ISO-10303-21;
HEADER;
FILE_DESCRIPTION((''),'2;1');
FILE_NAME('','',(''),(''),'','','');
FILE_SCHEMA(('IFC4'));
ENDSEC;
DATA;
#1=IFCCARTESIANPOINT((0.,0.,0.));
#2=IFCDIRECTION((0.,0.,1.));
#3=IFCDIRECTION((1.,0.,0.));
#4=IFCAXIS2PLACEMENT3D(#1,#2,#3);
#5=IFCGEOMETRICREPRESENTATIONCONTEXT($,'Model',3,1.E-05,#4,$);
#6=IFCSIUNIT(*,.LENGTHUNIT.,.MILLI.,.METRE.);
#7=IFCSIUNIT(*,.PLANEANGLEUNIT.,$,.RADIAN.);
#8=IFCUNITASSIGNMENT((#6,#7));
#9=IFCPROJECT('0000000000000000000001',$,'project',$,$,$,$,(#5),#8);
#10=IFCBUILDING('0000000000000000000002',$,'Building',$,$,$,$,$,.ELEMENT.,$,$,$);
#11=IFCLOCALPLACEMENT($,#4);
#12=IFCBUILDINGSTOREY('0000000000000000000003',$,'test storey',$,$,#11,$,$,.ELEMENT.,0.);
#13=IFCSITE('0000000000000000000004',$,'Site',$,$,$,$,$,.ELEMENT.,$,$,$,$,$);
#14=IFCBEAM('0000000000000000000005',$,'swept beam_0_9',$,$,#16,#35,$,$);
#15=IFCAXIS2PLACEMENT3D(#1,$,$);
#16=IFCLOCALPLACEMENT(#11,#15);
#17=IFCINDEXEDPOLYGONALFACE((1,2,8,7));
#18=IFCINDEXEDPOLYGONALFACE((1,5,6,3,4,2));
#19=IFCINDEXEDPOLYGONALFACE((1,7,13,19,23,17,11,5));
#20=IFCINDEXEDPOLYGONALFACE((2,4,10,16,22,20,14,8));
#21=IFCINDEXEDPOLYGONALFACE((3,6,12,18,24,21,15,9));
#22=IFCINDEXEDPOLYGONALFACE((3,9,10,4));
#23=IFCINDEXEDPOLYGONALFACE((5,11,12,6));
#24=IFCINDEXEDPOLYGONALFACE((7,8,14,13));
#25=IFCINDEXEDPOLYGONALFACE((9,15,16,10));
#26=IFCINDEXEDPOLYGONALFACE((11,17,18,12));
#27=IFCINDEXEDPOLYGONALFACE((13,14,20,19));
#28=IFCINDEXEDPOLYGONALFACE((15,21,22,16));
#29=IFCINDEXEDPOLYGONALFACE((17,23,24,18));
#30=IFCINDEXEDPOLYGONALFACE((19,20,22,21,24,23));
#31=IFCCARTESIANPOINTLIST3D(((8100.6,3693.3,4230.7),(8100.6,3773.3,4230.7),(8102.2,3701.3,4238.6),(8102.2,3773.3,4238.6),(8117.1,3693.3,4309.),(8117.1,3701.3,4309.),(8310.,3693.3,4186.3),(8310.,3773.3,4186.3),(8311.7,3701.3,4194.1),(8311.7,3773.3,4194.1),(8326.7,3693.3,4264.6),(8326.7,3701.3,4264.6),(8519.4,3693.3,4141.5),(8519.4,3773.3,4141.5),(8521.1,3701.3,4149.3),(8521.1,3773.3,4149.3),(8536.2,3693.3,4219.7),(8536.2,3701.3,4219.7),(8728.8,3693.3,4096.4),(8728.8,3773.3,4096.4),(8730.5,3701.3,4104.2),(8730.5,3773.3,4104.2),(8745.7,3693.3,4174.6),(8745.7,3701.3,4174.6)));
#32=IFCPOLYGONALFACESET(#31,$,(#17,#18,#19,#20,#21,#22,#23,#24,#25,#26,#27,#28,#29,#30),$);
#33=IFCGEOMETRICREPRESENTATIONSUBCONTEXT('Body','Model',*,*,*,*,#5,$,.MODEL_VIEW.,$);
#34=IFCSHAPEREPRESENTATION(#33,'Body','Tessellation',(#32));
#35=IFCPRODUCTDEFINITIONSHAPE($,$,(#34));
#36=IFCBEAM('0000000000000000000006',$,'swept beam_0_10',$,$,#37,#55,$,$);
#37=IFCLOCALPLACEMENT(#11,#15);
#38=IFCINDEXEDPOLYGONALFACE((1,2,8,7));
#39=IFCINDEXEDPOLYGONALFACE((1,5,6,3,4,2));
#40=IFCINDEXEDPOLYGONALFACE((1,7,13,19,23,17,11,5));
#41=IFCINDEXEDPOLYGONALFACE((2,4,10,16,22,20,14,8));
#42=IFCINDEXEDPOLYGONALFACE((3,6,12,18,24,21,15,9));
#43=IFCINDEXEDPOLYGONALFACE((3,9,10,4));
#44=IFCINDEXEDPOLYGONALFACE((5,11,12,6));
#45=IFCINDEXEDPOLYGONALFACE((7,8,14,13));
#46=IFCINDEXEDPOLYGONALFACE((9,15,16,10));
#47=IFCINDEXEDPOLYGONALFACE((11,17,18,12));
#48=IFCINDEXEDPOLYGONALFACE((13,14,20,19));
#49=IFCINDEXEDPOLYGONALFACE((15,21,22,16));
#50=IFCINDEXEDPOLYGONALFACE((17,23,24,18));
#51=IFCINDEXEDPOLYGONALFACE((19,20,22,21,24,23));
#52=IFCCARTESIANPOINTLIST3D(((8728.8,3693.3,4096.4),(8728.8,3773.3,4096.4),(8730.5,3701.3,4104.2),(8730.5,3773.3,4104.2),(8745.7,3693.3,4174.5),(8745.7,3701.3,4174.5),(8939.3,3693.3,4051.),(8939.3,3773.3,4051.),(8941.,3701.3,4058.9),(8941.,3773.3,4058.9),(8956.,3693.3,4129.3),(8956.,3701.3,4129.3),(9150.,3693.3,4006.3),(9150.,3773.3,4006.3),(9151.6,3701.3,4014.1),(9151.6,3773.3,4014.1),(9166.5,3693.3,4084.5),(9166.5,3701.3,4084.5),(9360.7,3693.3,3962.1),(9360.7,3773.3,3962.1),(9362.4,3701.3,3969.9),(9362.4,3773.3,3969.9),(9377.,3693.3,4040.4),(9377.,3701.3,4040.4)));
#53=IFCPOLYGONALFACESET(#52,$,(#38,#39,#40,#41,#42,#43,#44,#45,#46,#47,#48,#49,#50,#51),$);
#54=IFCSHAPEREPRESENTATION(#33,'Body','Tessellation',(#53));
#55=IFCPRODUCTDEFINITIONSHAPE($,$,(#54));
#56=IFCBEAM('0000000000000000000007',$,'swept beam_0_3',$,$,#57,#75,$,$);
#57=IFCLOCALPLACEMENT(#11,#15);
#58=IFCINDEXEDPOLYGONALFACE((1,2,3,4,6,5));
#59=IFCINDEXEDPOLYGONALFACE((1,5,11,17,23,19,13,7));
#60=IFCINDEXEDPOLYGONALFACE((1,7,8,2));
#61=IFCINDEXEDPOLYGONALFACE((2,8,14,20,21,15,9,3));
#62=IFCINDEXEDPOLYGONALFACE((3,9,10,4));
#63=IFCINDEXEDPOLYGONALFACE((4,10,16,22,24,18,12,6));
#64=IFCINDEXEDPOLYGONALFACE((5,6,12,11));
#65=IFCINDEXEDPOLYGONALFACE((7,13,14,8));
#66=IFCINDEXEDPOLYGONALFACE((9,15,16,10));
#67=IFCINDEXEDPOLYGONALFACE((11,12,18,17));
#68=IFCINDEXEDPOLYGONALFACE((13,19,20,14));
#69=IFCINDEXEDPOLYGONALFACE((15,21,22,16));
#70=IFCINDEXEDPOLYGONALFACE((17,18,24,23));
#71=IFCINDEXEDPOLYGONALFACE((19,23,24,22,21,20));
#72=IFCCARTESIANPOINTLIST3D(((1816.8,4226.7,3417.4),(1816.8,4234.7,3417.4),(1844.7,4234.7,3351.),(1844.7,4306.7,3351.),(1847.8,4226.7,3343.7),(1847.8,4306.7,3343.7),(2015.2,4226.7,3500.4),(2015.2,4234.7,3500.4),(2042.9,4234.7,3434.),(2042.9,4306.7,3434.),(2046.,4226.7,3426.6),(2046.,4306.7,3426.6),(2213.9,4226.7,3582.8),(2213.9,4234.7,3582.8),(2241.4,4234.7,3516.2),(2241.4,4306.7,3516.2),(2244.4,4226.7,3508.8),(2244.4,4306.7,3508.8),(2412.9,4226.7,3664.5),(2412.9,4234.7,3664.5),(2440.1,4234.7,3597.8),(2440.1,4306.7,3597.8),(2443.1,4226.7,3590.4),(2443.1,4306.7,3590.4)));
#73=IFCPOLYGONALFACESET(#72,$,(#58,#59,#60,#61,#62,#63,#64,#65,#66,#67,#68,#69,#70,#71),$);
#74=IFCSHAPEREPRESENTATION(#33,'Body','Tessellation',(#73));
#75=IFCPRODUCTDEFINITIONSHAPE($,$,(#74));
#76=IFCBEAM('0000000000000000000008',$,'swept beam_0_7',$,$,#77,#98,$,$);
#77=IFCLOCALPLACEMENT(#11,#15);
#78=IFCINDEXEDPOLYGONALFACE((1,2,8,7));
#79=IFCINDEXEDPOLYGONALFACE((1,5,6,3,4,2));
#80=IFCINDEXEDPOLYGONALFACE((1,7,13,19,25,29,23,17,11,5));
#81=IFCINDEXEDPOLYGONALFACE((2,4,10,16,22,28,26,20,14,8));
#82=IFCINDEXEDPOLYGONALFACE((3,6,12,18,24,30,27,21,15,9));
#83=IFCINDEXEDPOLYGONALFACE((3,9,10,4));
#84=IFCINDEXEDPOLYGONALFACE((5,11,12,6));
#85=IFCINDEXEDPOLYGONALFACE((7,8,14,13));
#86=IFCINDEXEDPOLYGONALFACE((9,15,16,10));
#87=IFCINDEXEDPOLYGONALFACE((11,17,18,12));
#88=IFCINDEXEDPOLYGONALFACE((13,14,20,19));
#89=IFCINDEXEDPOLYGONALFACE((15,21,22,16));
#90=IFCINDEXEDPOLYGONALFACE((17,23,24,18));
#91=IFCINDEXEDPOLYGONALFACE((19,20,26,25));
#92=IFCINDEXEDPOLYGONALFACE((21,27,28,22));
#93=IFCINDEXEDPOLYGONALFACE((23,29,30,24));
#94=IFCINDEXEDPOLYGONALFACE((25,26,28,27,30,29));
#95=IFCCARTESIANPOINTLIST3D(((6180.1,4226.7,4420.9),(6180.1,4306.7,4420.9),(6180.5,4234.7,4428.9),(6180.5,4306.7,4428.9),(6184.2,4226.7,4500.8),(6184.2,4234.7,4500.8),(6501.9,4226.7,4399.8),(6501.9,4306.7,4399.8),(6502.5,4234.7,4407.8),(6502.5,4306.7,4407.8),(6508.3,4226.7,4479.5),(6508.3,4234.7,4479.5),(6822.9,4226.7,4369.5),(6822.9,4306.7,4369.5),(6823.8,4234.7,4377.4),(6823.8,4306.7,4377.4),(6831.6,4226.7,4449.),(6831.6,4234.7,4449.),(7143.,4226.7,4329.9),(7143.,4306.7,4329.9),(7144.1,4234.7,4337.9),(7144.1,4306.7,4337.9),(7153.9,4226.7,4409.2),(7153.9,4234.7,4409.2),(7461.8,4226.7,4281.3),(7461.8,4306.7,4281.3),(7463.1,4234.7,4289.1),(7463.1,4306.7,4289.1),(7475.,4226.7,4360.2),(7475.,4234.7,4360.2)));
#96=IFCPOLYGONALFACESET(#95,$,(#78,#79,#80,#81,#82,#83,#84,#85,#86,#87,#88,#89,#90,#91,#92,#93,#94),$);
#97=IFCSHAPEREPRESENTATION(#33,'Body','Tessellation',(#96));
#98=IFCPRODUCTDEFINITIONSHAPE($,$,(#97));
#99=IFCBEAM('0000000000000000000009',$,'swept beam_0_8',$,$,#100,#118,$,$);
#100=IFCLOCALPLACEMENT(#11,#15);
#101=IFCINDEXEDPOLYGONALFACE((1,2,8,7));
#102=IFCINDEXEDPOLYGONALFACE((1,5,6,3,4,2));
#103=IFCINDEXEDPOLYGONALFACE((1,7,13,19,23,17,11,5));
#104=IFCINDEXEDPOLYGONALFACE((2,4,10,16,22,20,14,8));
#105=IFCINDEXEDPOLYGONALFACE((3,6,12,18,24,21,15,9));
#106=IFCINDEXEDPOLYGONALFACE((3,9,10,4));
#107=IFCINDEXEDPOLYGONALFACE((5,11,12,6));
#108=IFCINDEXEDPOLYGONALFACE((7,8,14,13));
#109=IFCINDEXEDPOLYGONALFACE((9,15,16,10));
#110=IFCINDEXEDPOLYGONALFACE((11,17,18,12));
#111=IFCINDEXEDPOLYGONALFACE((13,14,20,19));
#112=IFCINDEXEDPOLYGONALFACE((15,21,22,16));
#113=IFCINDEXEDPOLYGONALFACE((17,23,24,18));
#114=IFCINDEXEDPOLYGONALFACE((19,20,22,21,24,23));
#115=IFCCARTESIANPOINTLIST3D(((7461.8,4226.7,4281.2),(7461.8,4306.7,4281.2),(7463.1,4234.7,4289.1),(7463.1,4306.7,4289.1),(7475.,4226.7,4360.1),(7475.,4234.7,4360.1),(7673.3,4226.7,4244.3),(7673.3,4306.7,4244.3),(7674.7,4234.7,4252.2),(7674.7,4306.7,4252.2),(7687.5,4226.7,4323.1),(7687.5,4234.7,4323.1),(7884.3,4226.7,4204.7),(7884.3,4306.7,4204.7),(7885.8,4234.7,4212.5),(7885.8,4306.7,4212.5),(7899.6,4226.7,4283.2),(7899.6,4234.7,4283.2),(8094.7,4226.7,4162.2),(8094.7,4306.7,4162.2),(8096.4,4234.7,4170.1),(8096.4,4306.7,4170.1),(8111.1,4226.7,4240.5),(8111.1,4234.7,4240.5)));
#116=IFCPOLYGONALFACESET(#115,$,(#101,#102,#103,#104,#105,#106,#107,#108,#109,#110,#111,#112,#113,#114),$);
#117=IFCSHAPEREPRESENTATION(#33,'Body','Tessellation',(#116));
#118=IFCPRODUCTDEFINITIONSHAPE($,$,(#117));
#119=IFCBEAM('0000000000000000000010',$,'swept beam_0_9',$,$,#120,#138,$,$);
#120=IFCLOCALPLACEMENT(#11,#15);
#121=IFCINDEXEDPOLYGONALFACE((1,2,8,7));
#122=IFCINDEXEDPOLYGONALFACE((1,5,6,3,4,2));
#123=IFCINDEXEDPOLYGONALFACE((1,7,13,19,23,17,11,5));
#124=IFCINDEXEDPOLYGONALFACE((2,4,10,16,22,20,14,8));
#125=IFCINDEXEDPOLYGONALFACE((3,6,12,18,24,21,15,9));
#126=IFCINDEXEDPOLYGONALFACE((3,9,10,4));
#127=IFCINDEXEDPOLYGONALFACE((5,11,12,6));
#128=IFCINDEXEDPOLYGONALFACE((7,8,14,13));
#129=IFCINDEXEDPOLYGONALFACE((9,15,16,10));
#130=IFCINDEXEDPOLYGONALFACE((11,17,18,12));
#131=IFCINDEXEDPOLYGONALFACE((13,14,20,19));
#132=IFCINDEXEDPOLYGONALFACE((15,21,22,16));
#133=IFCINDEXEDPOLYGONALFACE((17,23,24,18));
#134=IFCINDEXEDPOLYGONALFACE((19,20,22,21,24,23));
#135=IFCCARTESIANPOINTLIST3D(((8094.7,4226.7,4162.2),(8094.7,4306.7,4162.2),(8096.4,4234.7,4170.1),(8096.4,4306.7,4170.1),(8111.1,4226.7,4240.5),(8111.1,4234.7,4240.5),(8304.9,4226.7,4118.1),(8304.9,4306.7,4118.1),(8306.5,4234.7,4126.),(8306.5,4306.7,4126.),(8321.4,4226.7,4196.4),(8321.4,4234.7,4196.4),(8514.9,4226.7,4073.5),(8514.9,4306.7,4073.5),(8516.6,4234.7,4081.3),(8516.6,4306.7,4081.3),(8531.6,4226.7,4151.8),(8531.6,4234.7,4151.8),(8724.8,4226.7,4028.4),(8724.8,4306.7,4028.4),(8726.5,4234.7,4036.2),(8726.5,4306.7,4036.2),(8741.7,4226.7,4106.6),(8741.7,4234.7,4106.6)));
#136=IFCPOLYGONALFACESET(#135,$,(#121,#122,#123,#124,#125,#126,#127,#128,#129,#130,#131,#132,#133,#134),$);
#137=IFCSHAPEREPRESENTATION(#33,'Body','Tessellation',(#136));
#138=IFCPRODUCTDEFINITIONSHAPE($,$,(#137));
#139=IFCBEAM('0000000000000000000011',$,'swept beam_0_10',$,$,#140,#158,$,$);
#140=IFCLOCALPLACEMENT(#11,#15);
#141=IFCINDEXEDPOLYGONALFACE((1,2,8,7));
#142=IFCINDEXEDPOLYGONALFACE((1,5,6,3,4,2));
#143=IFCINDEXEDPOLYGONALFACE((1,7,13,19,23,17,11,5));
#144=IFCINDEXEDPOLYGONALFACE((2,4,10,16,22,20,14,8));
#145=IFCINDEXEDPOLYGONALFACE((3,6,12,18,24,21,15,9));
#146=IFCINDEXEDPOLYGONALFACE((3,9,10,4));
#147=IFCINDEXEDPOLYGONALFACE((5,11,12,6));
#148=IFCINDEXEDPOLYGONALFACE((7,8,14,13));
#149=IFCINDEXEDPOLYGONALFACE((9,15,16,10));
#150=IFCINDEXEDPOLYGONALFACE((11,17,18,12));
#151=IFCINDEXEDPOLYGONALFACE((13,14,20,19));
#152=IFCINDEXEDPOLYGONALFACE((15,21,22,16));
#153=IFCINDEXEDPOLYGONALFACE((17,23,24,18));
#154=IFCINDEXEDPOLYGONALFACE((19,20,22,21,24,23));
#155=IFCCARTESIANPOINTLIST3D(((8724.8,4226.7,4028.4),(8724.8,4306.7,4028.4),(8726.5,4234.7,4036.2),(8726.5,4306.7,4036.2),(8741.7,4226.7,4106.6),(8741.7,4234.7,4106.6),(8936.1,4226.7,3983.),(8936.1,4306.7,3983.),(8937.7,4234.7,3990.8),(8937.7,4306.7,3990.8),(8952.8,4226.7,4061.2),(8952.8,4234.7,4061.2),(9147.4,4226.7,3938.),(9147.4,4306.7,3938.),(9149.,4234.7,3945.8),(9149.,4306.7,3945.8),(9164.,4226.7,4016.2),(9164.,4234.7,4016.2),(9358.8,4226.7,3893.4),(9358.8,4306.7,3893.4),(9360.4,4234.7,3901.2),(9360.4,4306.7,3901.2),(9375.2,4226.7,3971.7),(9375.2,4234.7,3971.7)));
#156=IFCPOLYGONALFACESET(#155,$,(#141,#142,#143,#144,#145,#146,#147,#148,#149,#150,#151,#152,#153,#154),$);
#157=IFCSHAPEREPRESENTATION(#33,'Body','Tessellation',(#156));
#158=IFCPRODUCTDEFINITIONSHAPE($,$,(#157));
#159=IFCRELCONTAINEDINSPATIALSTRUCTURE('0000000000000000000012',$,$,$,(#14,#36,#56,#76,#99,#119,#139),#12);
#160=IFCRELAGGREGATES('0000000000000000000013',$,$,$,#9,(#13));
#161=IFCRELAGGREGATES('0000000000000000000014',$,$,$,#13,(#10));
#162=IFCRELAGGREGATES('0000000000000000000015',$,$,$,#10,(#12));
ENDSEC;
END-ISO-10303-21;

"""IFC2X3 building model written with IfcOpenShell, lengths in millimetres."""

from ifc_helpers import new_model, entity, si_unit, origin_with_axes, place, context, subcontext, project, spatial, element, save


model = new_model("IFC2X3")

# Units and contexts
model_context = context("Model", 3, precision=1e-05, world=origin_with_axes())
body_context = subcontext(model_context, "Body", "Model", "MODEL_VIEW")
ifc_project = project(units=[si_unit("LENGTHUNIT", "METRE", prefix="MILLI"), si_unit("PLANEANGLEUNIT", "RADIAN")], contexts=[model_context])

# Site, building, storey
site = spatial("IfcSite", under=ifc_project, Name="Site", CompositionType="ELEMENT")
building = spatial("IfcBuilding", under=site, Name="Building", CompositionType="ELEMENT")
storey_placement = place(None, origin_with_axes())
storey = spatial("IfcBuildingStorey", under=building, at=storey_placement, Name="test storey", CompositionType="ELEMENT", Elevation=0.0)

# Beams
beam_1_placement = place(storey_placement, origin_with_axes())
element("IfcBeam", 1, at=beam_1_placement, inside=storey, Name="swept beam_0_9", context=body_context, shape_type="SweptSolid", body=[
    entity("IfcRevolvedAreaSolid", entity("IfcArbitraryClosedProfileDef", "AREA", None, entity("IfcPolyline", [entity("IfcCartesianPoint", [80.0, -40.0]), entity("IfcCartesianPoint", [80.0, -32.0]), entity("IfcCartesianPoint", [8.0, -32.0]), entity("IfcCartesianPoint", [8.0, 40.0]), entity("IfcCartesianPoint", [0.0, 40.0]), entity("IfcCartesianPoint", [0.0, -40.0]), entity("IfcCartesianPoint", [80.0, -40.0])])), entity("IfcAxis2Placement3D", entity("IfcCartesianPoint", [8100.6, 3733.3, 4230.7]), entity("IfcDirection", [-0.9784, 0.0, 0.2066]), entity("IfcDirection", [0.2066, 0.0, 0.9784])), entity("IfcAxis1Placement", entity("IfcCartesianPoint", [-121948.0, 0.0, 0.0]), entity("IfcDirection", [0.0, 1.0, 0.0])), 0.005268),
])
beam_2_placement = place(storey_placement, origin_with_axes())
element("IfcBeam", 2, at=beam_2_placement, inside=storey, Name="swept beam_0_10", context=body_context, shape_type="SweptSolid", body=[
    entity("IfcRevolvedAreaSolid", entity("IfcArbitraryClosedProfileDef", "AREA", None, entity("IfcPolyline", [entity("IfcCartesianPoint", [-80.0, 40.0]), entity("IfcCartesianPoint", [-80.0, 32.0]), entity("IfcCartesianPoint", [-8.0, 32.0]), entity("IfcCartesianPoint", [-8.0, -40.0]), entity("IfcCartesianPoint", [0.0, -40.0]), entity("IfcCartesianPoint", [0.0, 40.0]), entity("IfcCartesianPoint", [-80.0, 40.0])])), entity("IfcAxis2Placement3D", entity("IfcCartesianPoint", [8728.8, 3733.3, 4096.4]), entity("IfcDirection", [-0.9773, 0.0, 0.2118]), entity("IfcDirection", [-0.2118, 0.0, -0.9773])), entity("IfcAxis1Placement", entity("IfcCartesianPoint", [-80423.0, 0.0, 0.0]), entity("IfcDirection", [0.0, 1.0, 0.0])), 0.008033),
])
beam_3_placement = place(storey_placement, origin_with_axes())
element("IfcBeam", 3, at=beam_3_placement, inside=storey, Name="swept beam_0_3", context=body_context, shape_type="SweptSolid", body=[
    entity("IfcRevolvedAreaSolid", entity("IfcArbitraryClosedProfileDef", "AREA", None, entity("IfcPolyline", [entity("IfcCartesianPoint", [80.0, -40.0]), entity("IfcCartesianPoint", [80.0, -32.0]), entity("IfcCartesianPoint", [8.0, -32.0]), entity("IfcCartesianPoint", [8.0, 40.0]), entity("IfcCartesianPoint", [0.0, 40.0]), entity("IfcCartesianPoint", [0.0, -40.0]), entity("IfcCartesianPoint", [80.0, -40.0])])), entity("IfcAxis2Placement3D", entity("IfcCartesianPoint", [1847.8, 4266.7, 3343.7]), entity("IfcDirection", [-0.9219, 0.0, -0.3874]), entity("IfcDirection", [-0.3874, 0.0, 0.9219])), entity("IfcAxis1Placement", entity("IfcCartesianPoint", [-65920.5, 0.0, 0.0]), entity("IfcDirection", [0.0, 1.0, 0.0])), 0.009777),
])
beam_4_placement = place(storey_placement, origin_with_axes())
element("IfcBeam", 4, at=beam_4_placement, inside=storey, Name="swept beam_0_7", context=body_context, shape_type="SweptSolid", body=[
    entity("IfcRevolvedAreaSolid", entity("IfcArbitraryClosedProfileDef", "AREA", None, entity("IfcPolyline", [entity("IfcCartesianPoint", [80.0, -40.0]), entity("IfcCartesianPoint", [80.0, -32.0]), entity("IfcCartesianPoint", [8.0, -32.0]), entity("IfcCartesianPoint", [8.0, 40.0]), entity("IfcCartesianPoint", [0.0, 40.0]), entity("IfcCartesianPoint", [0.0, -40.0]), entity("IfcCartesianPoint", [80.0, -40.0])])), entity("IfcAxis2Placement3D", entity("IfcCartesianPoint", [6180.1, 4266.7, 4420.9]), entity("IfcDirection", [-0.9987, 0.0, 0.0511]), entity("IfcDirection", [0.0511, 0.0, 0.9987])), entity("IfcAxis1Placement", entity("IfcCartesianPoint", [-11237.6, 0.0, 0.0]), entity("IfcDirection", [0.0, 1.0, 0.0])), 0.114789),
])
beam_5_placement = place(storey_placement, origin_with_axes())
element("IfcBeam", 5, at=beam_5_placement, inside=storey, Name="swept beam_0_8", context=body_context, shape_type="SweptSolid", body=[
    entity("IfcRevolvedAreaSolid", entity("IfcArbitraryClosedProfileDef", "AREA", None, entity("IfcPolyline", [entity("IfcCartesianPoint", [80.0, -40.0]), entity("IfcCartesianPoint", [80.0, -32.0]), entity("IfcCartesianPoint", [8.0, -32.0]), entity("IfcCartesianPoint", [8.0, 40.0]), entity("IfcCartesianPoint", [0.0, 40.0]), entity("IfcCartesianPoint", [0.0, -40.0]), entity("IfcCartesianPoint", [80.0, -40.0])])), entity("IfcAxis2Placement3D", entity("IfcCartesianPoint", [7461.8, 4266.7, 4281.2]), entity("IfcDirection", [-0.9863, 0.0, 0.1652]), entity("IfcDirection", [0.1652, 0.0, 0.9863])), entity("IfcAxis1Placement", entity("IfcCartesianPoint", [-16212.7, 0.0, 0.0]), entity("IfcDirection", [0.0, 1.0, 0.0])), 0.039727),
])
beam_6_placement = place(storey_placement, origin_with_axes())
element("IfcBeam", 6, at=beam_6_placement, inside=storey, Name="swept beam_0_9", context=body_context, shape_type="SweptSolid", body=[
    entity("IfcRevolvedAreaSolid", entity("IfcArbitraryClosedProfileDef", "AREA", None, entity("IfcPolyline", [entity("IfcCartesianPoint", [80.0, -40.0]), entity("IfcCartesianPoint", [80.0, -32.0]), entity("IfcCartesianPoint", [8.0, -32.0]), entity("IfcCartesianPoint", [8.0, 40.0]), entity("IfcCartesianPoint", [0.0, 40.0]), entity("IfcCartesianPoint", [0.0, -40.0]), entity("IfcCartesianPoint", [80.0, -40.0])])), entity("IfcAxis2Placement3D", entity("IfcCartesianPoint", [8094.7, 4266.7, 4162.2]), entity("IfcDirection", [-0.9789, 0.0, 0.2042]), entity("IfcDirection", [0.2042, 0.0, 0.9789])), entity("IfcAxis1Placement", entity("IfcCartesianPoint", [-89145.7, 0.0, 0.0]), entity("IfcDirection", [0.0, 1.0, 0.0])), 0.007226),
])
beam_7_placement = place(storey_placement, origin_with_axes())
element("IfcBeam", 7, at=beam_7_placement, inside=storey, Name="swept beam_0_10", context=body_context, shape_type="SweptSolid", body=[
    entity("IfcRevolvedAreaSolid", entity("IfcArbitraryClosedProfileDef", "AREA", None, entity("IfcPolyline", [entity("IfcCartesianPoint", [-80.0, 40.0]), entity("IfcCartesianPoint", [-80.0, 32.0]), entity("IfcCartesianPoint", [-8.0, 32.0]), entity("IfcCartesianPoint", [-8.0, -40.0]), entity("IfcCartesianPoint", [0.0, -40.0]), entity("IfcCartesianPoint", [0.0, 40.0]), entity("IfcCartesianPoint", [-80.0, 40.0])])), entity("IfcAxis2Placement3D", entity("IfcCartesianPoint", [8724.8, 4266.7, 4028.4]), entity("IfcDirection", [-0.9774, 0.0, 0.2113]), entity("IfcDirection", [-0.2113, 0.0, -0.9774])), entity("IfcAxis1Placement", entity("IfcCartesianPoint", [-106150.8, 0.0, 0.0]), entity("IfcDirection", [0.0, 1.0, 0.0])), 0.006106),
])

save(model, "model.ifc")
